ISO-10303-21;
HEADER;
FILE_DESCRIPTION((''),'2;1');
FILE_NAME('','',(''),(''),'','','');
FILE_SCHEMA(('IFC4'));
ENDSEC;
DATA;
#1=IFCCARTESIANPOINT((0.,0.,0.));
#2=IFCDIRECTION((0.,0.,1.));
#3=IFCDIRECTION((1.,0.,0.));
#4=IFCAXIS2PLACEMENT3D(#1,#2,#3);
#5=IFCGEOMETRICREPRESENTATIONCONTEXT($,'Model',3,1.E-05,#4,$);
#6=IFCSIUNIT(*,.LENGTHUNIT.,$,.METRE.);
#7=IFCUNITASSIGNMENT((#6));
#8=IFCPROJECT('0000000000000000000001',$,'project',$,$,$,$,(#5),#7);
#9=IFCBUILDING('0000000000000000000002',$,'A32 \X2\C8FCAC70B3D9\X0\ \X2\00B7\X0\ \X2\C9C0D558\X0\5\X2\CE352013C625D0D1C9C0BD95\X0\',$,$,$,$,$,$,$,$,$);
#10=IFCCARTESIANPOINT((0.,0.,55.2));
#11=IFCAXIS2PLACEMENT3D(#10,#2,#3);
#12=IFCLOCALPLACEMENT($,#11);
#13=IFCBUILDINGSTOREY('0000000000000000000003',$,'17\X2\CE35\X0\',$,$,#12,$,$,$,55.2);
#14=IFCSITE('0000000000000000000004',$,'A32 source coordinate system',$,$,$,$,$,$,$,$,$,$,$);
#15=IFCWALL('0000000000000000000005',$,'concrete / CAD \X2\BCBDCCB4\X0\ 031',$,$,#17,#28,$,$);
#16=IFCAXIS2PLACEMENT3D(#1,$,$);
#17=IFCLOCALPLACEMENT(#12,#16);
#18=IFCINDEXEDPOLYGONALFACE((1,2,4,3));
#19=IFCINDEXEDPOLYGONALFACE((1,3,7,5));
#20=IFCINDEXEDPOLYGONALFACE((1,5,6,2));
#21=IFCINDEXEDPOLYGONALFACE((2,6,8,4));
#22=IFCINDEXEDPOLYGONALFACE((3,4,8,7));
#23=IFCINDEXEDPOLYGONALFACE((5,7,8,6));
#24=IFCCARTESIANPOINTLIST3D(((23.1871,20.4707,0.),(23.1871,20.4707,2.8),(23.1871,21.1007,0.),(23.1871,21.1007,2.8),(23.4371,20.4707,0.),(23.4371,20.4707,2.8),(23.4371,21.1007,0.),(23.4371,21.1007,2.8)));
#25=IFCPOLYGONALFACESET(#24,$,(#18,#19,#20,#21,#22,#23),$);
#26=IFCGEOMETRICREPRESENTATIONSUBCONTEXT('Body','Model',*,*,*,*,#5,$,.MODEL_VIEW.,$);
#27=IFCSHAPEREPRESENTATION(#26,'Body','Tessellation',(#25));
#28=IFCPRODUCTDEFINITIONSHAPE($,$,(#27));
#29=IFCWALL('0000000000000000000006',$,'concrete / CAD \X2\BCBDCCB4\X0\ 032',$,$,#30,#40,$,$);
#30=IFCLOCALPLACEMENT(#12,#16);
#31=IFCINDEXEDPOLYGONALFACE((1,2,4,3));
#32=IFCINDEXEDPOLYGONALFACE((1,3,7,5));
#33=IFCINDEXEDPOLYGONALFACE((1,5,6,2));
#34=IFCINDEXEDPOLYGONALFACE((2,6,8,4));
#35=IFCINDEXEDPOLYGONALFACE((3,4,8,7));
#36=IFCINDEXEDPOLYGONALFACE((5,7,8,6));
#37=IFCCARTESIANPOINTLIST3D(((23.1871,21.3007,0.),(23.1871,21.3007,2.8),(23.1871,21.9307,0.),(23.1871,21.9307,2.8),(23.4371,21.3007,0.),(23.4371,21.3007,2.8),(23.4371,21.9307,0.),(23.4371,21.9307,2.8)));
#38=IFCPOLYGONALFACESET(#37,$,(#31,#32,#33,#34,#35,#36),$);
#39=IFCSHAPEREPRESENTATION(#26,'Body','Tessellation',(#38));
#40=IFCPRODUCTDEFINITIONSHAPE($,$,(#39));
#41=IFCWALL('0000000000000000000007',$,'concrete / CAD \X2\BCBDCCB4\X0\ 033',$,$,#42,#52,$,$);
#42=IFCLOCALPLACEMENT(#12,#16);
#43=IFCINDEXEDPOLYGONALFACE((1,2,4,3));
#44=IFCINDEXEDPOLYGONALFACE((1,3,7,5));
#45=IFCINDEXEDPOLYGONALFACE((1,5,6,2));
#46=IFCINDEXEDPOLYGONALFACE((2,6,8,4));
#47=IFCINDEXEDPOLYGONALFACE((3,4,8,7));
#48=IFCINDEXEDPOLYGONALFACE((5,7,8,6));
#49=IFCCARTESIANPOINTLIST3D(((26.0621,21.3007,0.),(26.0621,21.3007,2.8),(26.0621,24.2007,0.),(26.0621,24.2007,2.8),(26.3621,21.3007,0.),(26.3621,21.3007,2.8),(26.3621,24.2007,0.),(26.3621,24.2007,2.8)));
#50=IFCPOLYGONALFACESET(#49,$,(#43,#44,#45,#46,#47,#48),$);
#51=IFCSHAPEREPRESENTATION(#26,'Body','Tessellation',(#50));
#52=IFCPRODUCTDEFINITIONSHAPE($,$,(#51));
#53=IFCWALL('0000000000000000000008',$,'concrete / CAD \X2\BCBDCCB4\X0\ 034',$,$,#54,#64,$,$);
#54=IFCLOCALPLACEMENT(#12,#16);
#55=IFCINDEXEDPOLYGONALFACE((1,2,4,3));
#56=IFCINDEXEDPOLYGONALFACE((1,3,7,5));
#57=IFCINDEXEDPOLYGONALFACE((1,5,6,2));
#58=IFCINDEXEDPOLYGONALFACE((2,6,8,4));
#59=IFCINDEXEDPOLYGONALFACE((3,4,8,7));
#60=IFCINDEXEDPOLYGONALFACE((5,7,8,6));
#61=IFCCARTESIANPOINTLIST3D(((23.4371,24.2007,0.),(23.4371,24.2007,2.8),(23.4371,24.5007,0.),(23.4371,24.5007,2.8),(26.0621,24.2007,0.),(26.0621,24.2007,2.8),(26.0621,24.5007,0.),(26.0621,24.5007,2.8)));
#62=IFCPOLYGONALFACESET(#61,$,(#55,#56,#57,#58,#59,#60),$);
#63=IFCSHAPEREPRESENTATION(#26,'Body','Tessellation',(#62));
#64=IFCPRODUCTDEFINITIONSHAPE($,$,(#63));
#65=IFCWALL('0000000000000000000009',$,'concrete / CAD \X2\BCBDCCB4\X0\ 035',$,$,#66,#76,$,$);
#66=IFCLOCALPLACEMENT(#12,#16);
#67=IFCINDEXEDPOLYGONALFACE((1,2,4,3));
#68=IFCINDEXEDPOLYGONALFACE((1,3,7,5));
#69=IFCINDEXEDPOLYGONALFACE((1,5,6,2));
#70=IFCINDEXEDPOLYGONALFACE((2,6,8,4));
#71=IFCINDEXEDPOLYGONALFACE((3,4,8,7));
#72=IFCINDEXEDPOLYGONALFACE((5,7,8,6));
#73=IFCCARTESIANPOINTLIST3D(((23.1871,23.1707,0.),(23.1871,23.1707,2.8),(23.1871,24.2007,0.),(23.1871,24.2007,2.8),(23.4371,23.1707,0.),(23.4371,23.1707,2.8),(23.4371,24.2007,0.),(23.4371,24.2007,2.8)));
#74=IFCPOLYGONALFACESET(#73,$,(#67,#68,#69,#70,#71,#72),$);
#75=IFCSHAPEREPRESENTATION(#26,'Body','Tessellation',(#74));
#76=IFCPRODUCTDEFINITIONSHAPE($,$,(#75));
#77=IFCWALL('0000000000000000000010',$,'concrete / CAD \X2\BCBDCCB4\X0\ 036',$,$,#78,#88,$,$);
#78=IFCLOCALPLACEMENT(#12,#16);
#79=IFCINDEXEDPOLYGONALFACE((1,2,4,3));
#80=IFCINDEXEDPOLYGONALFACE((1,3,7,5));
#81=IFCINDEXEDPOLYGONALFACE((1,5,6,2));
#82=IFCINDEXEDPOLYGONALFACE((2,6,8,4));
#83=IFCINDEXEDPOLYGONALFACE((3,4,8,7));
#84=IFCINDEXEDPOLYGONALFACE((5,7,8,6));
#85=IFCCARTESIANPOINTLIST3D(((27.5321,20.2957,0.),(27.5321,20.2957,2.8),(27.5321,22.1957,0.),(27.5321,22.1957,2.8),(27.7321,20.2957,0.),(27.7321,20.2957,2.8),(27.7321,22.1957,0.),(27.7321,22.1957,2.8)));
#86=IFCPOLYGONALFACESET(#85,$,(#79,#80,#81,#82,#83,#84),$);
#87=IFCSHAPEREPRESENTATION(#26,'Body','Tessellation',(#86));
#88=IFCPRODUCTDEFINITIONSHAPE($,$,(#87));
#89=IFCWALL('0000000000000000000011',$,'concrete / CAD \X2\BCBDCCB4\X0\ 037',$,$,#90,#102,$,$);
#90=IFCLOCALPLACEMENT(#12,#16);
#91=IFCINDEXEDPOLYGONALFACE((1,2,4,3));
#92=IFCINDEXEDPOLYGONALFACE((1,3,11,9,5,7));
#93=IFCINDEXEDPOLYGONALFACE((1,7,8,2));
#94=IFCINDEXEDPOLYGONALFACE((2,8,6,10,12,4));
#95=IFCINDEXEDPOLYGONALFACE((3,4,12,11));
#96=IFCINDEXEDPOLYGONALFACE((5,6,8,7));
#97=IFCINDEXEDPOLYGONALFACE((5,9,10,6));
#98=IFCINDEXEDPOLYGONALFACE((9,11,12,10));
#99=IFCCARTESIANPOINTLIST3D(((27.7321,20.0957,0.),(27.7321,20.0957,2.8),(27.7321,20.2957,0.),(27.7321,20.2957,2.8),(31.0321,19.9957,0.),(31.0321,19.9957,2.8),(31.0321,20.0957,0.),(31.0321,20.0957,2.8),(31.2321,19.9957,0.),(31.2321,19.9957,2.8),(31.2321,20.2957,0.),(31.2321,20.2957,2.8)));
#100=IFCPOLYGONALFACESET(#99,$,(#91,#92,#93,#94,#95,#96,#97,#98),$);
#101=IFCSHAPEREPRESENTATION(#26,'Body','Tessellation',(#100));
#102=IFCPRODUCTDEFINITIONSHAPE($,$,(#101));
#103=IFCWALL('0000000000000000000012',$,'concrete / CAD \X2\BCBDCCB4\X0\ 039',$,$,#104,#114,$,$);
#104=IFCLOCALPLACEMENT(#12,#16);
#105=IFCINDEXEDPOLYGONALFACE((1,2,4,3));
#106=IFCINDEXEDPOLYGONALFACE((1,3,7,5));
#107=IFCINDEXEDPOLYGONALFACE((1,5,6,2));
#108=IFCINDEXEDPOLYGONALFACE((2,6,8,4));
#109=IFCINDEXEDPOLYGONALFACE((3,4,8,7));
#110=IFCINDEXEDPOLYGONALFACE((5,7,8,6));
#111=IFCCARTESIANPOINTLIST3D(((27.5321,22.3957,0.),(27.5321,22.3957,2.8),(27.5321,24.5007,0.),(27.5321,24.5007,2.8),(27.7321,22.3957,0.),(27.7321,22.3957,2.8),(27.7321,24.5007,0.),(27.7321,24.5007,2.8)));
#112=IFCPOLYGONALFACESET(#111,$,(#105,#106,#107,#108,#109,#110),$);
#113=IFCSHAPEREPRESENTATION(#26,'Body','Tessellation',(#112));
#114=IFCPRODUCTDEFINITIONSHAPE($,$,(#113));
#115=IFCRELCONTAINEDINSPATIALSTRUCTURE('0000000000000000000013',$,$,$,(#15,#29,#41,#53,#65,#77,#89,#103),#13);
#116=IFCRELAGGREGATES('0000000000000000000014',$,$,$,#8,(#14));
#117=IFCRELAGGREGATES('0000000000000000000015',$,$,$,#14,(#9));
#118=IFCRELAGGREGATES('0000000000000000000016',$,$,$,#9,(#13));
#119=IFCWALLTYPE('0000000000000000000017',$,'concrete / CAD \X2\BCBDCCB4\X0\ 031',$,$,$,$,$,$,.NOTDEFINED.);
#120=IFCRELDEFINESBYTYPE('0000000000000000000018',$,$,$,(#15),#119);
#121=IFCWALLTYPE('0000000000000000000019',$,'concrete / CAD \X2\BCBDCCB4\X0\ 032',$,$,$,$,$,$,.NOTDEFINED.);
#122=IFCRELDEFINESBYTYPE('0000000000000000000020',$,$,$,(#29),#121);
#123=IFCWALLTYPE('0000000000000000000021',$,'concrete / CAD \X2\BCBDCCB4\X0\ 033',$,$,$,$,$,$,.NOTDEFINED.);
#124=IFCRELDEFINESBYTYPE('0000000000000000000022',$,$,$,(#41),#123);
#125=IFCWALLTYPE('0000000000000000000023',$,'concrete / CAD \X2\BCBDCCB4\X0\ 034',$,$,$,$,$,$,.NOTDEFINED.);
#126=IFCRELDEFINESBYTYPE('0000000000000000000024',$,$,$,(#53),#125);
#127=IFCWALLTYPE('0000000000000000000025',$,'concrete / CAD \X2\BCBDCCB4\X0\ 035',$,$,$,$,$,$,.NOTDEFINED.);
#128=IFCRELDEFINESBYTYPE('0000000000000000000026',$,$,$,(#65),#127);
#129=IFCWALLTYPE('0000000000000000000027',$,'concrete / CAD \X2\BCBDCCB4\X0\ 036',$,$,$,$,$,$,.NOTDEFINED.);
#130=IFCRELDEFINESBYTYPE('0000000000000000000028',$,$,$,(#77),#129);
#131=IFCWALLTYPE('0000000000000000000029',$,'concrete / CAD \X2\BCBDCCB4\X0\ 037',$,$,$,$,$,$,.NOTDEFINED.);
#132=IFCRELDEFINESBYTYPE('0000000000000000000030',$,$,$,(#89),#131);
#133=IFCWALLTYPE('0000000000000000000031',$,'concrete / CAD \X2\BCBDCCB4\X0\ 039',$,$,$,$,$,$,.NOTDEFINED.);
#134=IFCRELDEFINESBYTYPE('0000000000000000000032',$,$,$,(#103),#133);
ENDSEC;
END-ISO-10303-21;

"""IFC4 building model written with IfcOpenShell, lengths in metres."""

from ifc_helpers import new_model, si_unit, frame, origin, origin_with_axes, place, context, subcontext, project, spatial, polyline, outline, extrude, source, transform, mapped, type_object, type_shapes, element, save


model = new_model("IFC4")

# Units and contexts
model_context = context("Model", 3, precision=1e-05, world=origin_with_axes())
body_context = subcontext(model_context, "Body", "Model", "MODEL_VIEW")
ifc_project = project(units=[si_unit("LENGTHUNIT", "METRE")], contexts=[model_context])

# Site, building, storey
site = spatial("IfcSite", under=ifc_project, Name="A32 source coordinate system")
building = spatial("IfcBuilding", under=site, Name="A32 주거동 · 지하5층–옥탑지붕")
storey_placement = place(None, frame((0.0, 0.0, 55.2), z_axis=(0.0, 0.0, 1.0), x_axis=(1.0, 0.0, 0.0)))
storey = spatial("IfcBuildingStorey", under=building, at=storey_placement, Name="17층", Elevation=55.2)

# Walls
wall_type_1 = type_object("IfcWallType", Name="concrete / CAD 벽체 031", PredefinedType="NOTDEFINED")
shared_shape_1 = source(origin(), body_context, "Body", "SweptSolid", [
    extrude(outline(polyline([(23.1871, 20.4707), (23.1871, 21.1007), (23.4371, 21.1007), (23.4371, 20.4707), (23.1871, 20.4707)])), origin(), (0.0, 0.0, 1.0), 2.8),
])
type_shapes(wall_type_1, [shared_shape_1])
wall_1_placement = place(storey_placement, origin_with_axes())
element("IfcWall", 1, at=wall_1_placement, inside=storey, type_object=wall_type_1, Name="concrete / CAD 벽체 031", context=body_context, shape_type="MappedRepresentation", body=[
    mapped(shared_shape_1, transform((0.0, 0.0, 0.0), scale=1.0)),
])
wall_type_2 = type_object("IfcWallType", Name="concrete / CAD 벽체 032", PredefinedType="NOTDEFINED")
shared_shape_2 = source(origin(), body_context, "Body", "SweptSolid", [
    extrude(outline(polyline([(23.4371, 21.9307), (23.4371, 21.3007), (23.1871, 21.3007), (23.1871, 21.9307), (23.4371, 21.9307)])), origin(), (0.0, 0.0, 1.0), 2.8),
])
type_shapes(wall_type_2, [shared_shape_2])
wall_2_placement = place(storey_placement, origin_with_axes())
element("IfcWall", 2, at=wall_2_placement, inside=storey, type_object=wall_type_2, Name="concrete / CAD 벽체 032", context=body_context, shape_type="MappedRepresentation", body=[
    mapped(shared_shape_2, transform((0.0, 0.0, 0.0), scale=1.0)),
])
wall_type_3 = type_object("IfcWallType", Name="concrete / CAD 벽체 033", PredefinedType="NOTDEFINED")
shared_shape_3 = source(origin(), body_context, "Body", "SweptSolid", [
    extrude(outline(polyline([(26.3621, 24.2007), (26.3621, 21.3007), (26.0621, 21.3007), (26.0621, 24.2007), (26.3621, 24.2007)])), origin(), (0.0, 0.0, 1.0), 2.8),
])
type_shapes(wall_type_3, [shared_shape_3])
wall_3_placement = place(storey_placement, origin_with_axes())
element("IfcWall", 3, at=wall_3_placement, inside=storey, type_object=wall_type_3, Name="concrete / CAD 벽체 033", context=body_context, shape_type="MappedRepresentation", body=[
    mapped(shared_shape_3, transform((0.0, 0.0, 0.0), scale=1.0)),
])
wall_type_4 = type_object("IfcWallType", Name="concrete / CAD 벽체 034", PredefinedType="NOTDEFINED")
shared_shape_4 = source(origin(), body_context, "Body", "SweptSolid", [
    extrude(outline(polyline([(23.4371, 24.5007), (26.0621, 24.5007), (26.0621, 24.2007), (23.4371, 24.2007), (23.4371, 24.5007)])), origin(), (0.0, 0.0, 1.0), 2.8),
])
type_shapes(wall_type_4, [shared_shape_4])
wall_4_placement = place(storey_placement, origin_with_axes())
element("IfcWall", 4, at=wall_4_placement, inside=storey, type_object=wall_type_4, Name="concrete / CAD 벽체 034", context=body_context, shape_type="MappedRepresentation", body=[
    mapped(shared_shape_4, transform((0.0, 0.0, 0.0), scale=1.0)),
])
wall_type_5 = type_object("IfcWallType", Name="concrete / CAD 벽체 035", PredefinedType="NOTDEFINED")
shared_shape_5 = source(origin(), body_context, "Body", "SweptSolid", [
    extrude(outline(polyline([(23.1871, 23.1707), (23.1871, 24.2007), (23.4371, 24.2007), (23.4371, 23.1707), (23.1871, 23.1707)])), origin(), (0.0, 0.0, 1.0), 2.8),
])
type_shapes(wall_type_5, [shared_shape_5])
wall_5_placement = place(storey_placement, origin_with_axes())
element("IfcWall", 5, at=wall_5_placement, inside=storey, type_object=wall_type_5, Name="concrete / CAD 벽체 035", context=body_context, shape_type="MappedRepresentation", body=[
    mapped(shared_shape_5, transform((0.0, 0.0, 0.0), scale=1.0)),
])
wall_type_6 = type_object("IfcWallType", Name="concrete / CAD 벽체 036", PredefinedType="NOTDEFINED")
shared_shape_6 = source(origin(), body_context, "Body", "SweptSolid", [
    extrude(outline(polyline([(27.7321, 22.1957), (27.7321, 20.2957), (27.5321, 20.2957), (27.5321, 22.1957), (27.7321, 22.1957)])), origin(), (0.0, 0.0, 1.0), 2.8),
])
type_shapes(wall_type_6, [shared_shape_6])
wall_6_placement = place(storey_placement, origin_with_axes())
element("IfcWall", 6, at=wall_6_placement, inside=storey, type_object=wall_type_6, Name="concrete / CAD 벽체 036", context=body_context, shape_type="MappedRepresentation", body=[
    mapped(shared_shape_6, transform((0.0, 0.0, 0.0), scale=1.0)),
])
wall_type_7 = type_object("IfcWallType", Name="concrete / CAD 벽체 037", PredefinedType="NOTDEFINED")
shared_shape_7 = source(origin(), body_context, "Body", "SweptSolid", [
    extrude(outline(polyline([(31.2321, 19.9957), (31.0321, 19.9957), (31.0321, 20.0957), (27.7321, 20.0957), (27.7321, 20.2957), (31.2321, 20.2957), (31.2321, 19.9957)])), origin(), (0.0, 0.0, 1.0), 2.8),
])
type_shapes(wall_type_7, [shared_shape_7])
wall_7_placement = place(storey_placement, origin_with_axes())
element("IfcWall", 7, at=wall_7_placement, inside=storey, type_object=wall_type_7, Name="concrete / CAD 벽체 037", context=body_context, shape_type="MappedRepresentation", body=[
    mapped(shared_shape_7, transform((0.0, 0.0, 0.0), scale=1.0)),
])
wall_type_8 = type_object("IfcWallType", Name="concrete / CAD 벽체 039", PredefinedType="NOTDEFINED")
shared_shape_8 = source(origin(), body_context, "Body", "SweptSolid", [
    extrude(outline(polyline([(27.7321, 24.5007), (27.7321, 22.3957), (27.5321, 22.3957), (27.5321, 24.5007), (27.7321, 24.5007)])), origin(), (0.0, 0.0, 1.0), 2.8),
])
type_shapes(wall_type_8, [shared_shape_8])
wall_8_placement = place(storey_placement, origin_with_axes())
element("IfcWall", 8, at=wall_8_placement, inside=storey, type_object=wall_type_8, Name="concrete / CAD 벽체 039", context=body_context, shape_type="MappedRepresentation", body=[
    mapped(shared_shape_8, transform((0.0, 0.0, 0.0), scale=1.0)),
])

save(model, "model.ifc")
